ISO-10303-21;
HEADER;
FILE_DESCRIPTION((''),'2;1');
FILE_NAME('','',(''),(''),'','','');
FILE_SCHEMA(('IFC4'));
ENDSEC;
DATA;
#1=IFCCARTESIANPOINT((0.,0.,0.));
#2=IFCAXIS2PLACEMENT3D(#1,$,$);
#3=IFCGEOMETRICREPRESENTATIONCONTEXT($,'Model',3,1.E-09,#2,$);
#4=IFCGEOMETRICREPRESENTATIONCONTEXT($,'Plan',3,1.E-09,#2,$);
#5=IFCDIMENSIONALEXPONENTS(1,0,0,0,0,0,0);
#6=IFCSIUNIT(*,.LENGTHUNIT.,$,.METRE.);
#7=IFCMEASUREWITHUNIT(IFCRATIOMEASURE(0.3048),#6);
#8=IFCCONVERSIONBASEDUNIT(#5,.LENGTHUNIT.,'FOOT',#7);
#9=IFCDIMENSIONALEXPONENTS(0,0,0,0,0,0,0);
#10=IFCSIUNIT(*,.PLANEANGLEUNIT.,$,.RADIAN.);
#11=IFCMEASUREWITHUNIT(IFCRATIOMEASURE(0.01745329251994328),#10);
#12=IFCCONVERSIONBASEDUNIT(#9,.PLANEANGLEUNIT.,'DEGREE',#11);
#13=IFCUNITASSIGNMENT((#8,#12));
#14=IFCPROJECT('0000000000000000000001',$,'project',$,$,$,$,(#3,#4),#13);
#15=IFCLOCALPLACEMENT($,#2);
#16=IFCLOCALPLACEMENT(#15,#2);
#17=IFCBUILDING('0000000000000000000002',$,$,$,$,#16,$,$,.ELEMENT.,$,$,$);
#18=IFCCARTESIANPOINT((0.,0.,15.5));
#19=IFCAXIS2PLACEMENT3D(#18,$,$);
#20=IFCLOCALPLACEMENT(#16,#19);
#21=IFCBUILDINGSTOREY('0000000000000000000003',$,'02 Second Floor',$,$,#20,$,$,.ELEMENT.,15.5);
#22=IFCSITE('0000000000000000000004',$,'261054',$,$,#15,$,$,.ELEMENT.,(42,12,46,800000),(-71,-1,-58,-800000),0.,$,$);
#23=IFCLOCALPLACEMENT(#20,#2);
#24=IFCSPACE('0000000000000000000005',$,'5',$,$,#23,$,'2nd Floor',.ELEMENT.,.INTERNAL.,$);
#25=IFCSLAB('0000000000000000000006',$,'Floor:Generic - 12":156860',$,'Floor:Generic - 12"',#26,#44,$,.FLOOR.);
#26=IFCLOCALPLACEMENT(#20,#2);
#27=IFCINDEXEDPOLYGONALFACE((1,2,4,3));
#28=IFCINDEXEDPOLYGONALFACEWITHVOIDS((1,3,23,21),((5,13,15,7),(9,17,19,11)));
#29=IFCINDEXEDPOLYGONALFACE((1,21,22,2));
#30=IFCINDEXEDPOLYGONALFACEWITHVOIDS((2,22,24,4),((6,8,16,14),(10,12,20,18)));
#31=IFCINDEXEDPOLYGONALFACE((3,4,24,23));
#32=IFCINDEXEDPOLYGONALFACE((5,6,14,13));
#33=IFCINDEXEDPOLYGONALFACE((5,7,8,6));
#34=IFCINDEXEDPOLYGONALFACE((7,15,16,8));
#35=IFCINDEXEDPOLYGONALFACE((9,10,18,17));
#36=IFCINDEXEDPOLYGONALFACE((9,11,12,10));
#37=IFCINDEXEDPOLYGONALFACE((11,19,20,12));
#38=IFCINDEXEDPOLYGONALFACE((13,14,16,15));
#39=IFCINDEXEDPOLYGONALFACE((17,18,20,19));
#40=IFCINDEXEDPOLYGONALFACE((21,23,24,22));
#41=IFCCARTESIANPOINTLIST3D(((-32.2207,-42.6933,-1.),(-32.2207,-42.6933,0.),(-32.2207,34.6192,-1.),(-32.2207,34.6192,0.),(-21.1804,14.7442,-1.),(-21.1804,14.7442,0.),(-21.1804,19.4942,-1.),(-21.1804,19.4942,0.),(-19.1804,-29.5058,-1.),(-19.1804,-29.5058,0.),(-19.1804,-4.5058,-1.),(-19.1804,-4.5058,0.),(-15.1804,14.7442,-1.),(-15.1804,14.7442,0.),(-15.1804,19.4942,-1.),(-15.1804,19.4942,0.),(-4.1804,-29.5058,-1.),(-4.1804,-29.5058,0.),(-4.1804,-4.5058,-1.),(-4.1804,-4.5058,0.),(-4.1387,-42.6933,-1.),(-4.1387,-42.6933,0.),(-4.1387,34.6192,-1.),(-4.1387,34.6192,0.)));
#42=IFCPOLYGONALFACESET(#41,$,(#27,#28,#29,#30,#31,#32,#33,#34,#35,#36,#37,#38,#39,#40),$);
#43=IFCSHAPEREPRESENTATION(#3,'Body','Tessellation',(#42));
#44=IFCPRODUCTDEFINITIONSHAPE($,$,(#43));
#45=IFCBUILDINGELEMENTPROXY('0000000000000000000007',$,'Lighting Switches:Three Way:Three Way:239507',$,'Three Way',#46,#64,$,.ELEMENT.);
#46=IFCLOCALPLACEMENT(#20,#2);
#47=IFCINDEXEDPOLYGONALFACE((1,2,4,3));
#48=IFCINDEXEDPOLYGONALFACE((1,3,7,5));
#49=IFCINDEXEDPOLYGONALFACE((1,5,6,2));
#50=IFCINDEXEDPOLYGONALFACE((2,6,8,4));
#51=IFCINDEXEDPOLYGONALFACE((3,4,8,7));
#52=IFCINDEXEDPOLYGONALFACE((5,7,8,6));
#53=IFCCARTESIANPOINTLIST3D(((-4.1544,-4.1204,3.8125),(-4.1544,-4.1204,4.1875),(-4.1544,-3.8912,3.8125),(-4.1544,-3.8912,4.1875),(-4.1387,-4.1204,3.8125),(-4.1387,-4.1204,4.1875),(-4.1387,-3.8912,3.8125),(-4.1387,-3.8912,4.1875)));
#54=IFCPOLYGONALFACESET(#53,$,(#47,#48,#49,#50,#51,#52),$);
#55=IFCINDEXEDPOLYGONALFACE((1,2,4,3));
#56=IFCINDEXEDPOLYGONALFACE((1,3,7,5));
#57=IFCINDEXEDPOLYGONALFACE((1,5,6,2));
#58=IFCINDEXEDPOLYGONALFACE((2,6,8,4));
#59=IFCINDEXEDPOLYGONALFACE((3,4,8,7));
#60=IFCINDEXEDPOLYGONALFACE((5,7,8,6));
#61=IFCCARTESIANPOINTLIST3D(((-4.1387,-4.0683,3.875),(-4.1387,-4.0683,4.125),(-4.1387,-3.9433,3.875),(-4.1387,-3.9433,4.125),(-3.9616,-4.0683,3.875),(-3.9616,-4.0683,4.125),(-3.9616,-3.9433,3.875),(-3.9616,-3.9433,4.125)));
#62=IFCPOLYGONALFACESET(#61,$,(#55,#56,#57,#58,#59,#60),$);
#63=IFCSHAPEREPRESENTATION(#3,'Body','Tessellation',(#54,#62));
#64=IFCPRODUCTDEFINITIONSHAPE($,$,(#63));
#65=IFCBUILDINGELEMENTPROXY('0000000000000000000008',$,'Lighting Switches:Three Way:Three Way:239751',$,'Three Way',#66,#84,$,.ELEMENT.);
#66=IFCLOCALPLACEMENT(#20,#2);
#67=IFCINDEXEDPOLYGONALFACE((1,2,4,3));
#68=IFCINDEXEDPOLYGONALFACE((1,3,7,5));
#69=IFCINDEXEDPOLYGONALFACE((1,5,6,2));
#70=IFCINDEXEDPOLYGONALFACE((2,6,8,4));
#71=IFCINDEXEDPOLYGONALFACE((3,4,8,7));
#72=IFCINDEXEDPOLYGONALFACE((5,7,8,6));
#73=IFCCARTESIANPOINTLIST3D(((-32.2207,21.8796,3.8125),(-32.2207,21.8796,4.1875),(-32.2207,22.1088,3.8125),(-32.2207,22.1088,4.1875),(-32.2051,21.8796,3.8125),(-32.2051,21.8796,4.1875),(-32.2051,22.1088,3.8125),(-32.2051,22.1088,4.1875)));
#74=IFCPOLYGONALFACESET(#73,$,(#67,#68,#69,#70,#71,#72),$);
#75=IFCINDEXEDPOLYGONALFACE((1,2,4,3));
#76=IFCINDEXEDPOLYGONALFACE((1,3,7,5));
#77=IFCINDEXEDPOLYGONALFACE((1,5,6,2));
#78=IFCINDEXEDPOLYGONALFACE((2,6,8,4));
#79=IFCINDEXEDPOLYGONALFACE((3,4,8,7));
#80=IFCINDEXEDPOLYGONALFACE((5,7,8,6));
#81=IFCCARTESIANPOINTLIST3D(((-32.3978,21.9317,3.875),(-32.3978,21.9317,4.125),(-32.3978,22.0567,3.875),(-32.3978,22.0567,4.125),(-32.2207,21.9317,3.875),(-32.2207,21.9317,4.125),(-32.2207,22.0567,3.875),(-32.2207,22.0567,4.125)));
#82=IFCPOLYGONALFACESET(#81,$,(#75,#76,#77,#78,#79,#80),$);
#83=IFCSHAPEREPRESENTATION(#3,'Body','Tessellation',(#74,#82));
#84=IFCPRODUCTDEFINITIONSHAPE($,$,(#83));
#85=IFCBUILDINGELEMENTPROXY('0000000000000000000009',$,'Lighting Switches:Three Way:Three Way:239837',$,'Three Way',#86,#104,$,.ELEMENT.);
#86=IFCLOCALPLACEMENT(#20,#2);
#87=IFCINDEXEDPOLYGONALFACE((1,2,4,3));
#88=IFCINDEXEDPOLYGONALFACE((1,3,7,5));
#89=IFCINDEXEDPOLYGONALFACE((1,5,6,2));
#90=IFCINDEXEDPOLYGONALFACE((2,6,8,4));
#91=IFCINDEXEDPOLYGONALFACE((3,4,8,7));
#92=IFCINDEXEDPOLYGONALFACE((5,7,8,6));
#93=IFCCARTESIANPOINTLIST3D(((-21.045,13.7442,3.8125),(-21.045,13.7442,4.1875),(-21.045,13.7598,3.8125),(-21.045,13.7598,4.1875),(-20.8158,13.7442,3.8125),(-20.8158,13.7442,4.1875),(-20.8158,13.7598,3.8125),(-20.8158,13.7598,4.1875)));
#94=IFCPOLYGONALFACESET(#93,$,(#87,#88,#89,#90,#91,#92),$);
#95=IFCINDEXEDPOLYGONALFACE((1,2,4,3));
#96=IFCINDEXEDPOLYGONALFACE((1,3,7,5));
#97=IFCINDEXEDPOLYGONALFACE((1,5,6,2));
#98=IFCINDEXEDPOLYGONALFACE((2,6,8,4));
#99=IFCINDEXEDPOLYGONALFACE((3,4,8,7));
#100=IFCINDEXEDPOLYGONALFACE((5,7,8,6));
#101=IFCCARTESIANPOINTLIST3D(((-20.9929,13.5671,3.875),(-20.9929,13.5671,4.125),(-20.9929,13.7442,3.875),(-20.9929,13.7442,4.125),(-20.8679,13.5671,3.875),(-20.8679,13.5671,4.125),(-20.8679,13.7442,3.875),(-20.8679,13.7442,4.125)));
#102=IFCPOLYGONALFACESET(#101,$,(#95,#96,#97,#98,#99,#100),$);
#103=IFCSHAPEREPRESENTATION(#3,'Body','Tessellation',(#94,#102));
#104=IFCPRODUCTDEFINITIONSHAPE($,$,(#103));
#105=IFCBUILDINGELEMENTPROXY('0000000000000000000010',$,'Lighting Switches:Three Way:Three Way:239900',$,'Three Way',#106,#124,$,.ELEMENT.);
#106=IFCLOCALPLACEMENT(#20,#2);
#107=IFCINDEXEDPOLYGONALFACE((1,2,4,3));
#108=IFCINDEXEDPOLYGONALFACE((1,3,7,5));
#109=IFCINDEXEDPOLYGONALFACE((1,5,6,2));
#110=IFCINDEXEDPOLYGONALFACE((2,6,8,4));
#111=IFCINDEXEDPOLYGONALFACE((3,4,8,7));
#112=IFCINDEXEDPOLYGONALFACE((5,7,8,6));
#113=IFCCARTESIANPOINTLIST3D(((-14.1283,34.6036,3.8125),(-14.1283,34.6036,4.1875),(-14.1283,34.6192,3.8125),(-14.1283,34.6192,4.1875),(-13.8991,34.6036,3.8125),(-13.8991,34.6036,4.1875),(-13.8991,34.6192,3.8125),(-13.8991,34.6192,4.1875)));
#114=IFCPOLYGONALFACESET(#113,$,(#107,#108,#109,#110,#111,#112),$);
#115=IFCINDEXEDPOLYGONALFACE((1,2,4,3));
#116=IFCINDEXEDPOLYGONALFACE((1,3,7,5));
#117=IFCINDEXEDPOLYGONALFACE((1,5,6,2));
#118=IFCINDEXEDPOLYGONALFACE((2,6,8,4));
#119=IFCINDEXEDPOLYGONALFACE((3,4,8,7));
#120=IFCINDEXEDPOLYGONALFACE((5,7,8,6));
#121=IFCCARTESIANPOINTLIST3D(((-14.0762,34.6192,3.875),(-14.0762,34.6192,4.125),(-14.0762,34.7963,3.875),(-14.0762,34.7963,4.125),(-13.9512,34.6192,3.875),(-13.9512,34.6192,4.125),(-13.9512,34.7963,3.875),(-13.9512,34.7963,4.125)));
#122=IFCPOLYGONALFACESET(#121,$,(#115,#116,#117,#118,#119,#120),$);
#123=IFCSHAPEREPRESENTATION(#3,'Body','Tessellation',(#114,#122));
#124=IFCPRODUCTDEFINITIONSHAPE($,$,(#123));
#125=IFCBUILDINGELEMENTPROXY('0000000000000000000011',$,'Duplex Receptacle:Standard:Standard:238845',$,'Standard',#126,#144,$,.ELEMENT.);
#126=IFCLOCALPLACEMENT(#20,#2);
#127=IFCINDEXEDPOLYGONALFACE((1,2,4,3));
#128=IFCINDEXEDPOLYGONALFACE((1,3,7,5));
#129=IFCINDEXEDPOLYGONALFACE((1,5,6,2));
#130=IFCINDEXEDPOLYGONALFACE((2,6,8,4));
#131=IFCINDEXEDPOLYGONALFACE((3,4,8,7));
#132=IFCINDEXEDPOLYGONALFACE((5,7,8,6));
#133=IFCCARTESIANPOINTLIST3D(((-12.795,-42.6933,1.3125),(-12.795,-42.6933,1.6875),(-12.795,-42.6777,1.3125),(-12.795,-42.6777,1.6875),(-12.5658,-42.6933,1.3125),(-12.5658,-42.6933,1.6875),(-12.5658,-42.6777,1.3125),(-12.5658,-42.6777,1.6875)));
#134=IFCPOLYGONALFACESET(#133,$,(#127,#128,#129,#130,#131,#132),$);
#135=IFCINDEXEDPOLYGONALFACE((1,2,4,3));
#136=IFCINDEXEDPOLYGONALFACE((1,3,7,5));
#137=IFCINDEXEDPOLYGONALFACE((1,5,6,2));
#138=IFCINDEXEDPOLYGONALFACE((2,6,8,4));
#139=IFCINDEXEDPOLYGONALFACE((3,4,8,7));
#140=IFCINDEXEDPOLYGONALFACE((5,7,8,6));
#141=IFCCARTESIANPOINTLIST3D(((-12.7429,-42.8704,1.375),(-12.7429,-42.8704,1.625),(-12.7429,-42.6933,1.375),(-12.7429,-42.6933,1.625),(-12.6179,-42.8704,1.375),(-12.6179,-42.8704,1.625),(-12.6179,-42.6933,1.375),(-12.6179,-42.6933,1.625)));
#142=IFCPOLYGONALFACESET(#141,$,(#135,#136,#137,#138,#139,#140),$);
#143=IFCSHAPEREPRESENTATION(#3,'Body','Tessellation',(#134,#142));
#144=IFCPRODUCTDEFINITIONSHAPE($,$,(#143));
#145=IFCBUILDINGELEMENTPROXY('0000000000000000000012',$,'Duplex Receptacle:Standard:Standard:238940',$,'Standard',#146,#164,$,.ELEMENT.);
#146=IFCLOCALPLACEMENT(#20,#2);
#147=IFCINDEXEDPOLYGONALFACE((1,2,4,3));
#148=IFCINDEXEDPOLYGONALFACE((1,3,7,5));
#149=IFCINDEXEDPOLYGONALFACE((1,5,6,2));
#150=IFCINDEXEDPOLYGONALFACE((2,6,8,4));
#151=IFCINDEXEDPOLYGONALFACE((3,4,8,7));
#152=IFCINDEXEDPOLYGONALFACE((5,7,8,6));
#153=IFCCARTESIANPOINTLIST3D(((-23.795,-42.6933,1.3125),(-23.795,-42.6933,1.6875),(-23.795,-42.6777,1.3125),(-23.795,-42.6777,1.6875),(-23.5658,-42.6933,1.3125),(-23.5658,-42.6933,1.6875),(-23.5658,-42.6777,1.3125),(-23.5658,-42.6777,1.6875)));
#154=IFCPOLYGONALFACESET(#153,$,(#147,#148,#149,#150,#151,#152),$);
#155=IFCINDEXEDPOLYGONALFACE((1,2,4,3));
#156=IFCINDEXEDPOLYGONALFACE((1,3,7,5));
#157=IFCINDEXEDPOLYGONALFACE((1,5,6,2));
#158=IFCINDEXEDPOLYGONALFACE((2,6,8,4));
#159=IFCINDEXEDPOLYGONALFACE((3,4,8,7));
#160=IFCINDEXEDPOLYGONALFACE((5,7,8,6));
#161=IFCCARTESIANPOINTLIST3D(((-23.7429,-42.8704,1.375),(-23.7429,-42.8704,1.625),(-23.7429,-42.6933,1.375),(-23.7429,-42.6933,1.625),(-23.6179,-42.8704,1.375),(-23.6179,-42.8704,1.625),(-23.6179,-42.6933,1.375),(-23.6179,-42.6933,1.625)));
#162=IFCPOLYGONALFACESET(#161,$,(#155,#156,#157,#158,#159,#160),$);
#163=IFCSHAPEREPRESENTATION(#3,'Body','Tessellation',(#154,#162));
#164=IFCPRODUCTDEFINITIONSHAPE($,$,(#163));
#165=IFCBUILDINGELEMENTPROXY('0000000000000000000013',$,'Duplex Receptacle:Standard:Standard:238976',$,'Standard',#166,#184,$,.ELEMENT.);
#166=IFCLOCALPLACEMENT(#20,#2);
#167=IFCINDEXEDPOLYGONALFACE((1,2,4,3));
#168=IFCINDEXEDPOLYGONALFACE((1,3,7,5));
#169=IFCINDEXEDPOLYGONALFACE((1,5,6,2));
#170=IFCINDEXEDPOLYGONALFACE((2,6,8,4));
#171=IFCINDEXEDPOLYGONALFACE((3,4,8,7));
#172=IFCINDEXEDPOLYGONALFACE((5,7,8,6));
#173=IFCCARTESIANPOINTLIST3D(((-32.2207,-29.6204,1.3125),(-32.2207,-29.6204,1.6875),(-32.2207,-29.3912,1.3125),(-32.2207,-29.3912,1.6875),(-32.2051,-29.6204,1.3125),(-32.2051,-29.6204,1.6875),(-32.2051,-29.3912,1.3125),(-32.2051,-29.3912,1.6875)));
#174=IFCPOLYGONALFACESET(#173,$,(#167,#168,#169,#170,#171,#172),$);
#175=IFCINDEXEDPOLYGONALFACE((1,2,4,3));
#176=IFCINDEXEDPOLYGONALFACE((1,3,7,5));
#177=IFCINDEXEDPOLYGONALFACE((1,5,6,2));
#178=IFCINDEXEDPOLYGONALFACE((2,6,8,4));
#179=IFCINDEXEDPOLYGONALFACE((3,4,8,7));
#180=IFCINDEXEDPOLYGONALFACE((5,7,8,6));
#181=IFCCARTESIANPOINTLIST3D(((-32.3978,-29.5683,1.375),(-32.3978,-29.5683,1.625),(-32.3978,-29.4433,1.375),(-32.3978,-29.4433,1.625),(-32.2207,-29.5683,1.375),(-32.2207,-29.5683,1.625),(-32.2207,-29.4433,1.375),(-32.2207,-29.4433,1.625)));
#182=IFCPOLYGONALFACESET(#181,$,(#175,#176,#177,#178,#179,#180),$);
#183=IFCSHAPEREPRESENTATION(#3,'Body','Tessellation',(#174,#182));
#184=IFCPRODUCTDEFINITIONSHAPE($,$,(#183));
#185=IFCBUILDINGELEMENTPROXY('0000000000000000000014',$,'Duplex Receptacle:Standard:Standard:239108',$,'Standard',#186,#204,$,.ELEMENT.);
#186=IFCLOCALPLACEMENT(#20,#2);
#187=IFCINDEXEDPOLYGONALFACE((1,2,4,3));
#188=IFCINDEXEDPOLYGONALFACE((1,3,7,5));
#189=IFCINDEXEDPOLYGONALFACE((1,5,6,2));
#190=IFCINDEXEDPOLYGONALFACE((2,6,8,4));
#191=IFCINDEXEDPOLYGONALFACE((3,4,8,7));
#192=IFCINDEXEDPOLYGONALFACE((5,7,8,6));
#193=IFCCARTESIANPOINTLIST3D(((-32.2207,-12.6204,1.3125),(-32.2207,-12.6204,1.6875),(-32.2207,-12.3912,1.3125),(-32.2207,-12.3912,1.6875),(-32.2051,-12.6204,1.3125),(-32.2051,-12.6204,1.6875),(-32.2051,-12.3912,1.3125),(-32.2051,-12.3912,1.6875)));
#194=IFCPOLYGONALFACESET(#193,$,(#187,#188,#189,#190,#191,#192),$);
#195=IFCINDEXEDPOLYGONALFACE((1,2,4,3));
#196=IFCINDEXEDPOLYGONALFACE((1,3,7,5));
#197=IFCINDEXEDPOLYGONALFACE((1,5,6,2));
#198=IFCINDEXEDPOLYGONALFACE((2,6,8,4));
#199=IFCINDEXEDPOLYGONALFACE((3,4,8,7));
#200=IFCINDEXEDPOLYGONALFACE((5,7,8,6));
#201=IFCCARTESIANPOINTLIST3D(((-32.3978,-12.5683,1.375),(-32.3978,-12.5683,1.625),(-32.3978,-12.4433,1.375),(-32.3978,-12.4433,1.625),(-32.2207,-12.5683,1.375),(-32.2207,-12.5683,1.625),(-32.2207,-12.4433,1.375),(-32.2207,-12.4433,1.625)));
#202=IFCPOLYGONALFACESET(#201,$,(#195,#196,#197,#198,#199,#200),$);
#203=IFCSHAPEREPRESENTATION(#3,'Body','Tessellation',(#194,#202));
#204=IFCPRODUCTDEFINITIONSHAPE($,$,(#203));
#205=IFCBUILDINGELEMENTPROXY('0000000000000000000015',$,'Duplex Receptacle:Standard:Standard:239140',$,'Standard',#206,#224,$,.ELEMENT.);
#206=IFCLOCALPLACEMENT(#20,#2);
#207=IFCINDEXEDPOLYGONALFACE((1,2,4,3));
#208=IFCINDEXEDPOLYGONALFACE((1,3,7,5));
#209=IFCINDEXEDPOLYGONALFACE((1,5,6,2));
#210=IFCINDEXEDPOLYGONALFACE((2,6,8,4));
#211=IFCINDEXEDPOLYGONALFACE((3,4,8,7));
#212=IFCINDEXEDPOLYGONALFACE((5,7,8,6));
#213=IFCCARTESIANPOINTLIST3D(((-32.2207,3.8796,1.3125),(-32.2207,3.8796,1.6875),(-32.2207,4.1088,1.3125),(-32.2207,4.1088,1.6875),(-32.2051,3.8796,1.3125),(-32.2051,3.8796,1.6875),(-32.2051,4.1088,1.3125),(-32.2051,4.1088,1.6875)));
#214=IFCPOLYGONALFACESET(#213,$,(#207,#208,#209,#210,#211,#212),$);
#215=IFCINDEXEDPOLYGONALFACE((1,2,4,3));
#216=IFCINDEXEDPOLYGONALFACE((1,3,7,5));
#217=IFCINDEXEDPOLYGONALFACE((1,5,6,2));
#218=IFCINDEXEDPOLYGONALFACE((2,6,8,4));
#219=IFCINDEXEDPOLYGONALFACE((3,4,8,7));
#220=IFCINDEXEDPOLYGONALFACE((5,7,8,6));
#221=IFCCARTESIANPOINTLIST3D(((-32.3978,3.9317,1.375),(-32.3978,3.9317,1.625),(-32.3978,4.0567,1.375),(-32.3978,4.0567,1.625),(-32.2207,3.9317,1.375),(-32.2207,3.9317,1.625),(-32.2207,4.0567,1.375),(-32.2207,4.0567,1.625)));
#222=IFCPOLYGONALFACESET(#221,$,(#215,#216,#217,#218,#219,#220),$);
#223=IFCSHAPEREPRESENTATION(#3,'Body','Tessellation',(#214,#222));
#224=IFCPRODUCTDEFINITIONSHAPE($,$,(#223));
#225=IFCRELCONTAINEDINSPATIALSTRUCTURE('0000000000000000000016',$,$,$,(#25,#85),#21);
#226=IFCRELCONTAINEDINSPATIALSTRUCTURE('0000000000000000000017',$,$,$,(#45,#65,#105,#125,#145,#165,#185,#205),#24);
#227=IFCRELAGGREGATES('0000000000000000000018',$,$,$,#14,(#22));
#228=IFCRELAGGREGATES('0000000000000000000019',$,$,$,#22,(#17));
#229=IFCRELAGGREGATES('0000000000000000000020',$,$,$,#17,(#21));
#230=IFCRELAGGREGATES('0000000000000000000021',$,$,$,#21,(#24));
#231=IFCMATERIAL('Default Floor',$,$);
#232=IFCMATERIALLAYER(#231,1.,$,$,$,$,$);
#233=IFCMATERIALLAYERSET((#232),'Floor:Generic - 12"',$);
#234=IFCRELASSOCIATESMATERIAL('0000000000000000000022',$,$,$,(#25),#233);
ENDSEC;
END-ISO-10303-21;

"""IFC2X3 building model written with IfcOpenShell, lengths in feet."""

from ifc_helpers import new_model, entity, si_unit, converted_unit, frame, frame_2d, origin, origin_2d_with_axis, place, context, project, spatial, rectangle, extrude, source, transform, mapped, material, layer, layer_set, layer_usage, element, save


model = new_model("IFC2X3")

# Units and contexts
model_context = context("Model", 3, precision=1e-09, world=origin())
plan_context = context("Plan", 3, precision=1e-09, world=origin())
ifc_project = project(units=[converted_unit("LENGTHUNIT", "FOOT", entity("IfcRatioMeasure", 0.3048), si_unit("LENGTHUNIT", "METRE"), dimensions=[1, 0, 0, 0, 0, 0, 0]), converted_unit("PLANEANGLEUNIT", "DEGREE", entity("IfcRatioMeasure", 0.01745329251994328), si_unit("PLANEANGLEUNIT", "RADIAN"), dimensions=[0, 0, 0, 0, 0, 0, 0])], contexts=[model_context, plan_context])

# Site, building, storey
site_placement = place(None, origin())
site = spatial("IfcSite", under=ifc_project, at=site_placement, Name="261054", CompositionType="ELEMENT", RefLatitude=(42, 12, 46, 800000), RefLongitude=(-71, -1, -58, -800000), RefElevation=0.0)
building_placement = place(site_placement, origin())
building = spatial("IfcBuilding", under=site, at=building_placement, CompositionType="ELEMENT")
storey_placement = place(building_placement, frame((0.0, 0.0, 15.5)))
storey = spatial("IfcBuildingStorey", under=building, at=storey_placement, Name="02 Second Floor", CompositionType="ELEMENT", Elevation=15.5)

# Slab, openings
ifc_material = material(Name="Default Floor")
ifc_layer = layer(ifc_material, 1.0)
ifc_layer_set = layer_set([ifc_layer], Name="Floor:Generic - 12\"")
ifc_layer_usage_1 = layer_usage(ifc_layer_set, "AXIS3", "POSITIVE", 0.0)
slab_1_placement = place(storey_placement, frame((-32.2207, -42.6933, -1.0)))
slab_1 = element("IfcSlab", 1, at=slab_1_placement, inside=storey, material=ifc_layer_usage_1, Name="Floor:Generic - 12\":156860", ObjectType="Floor:Generic - 12\"", PredefinedType="FLOOR", context=model_context, shape_type="SweptSolid", body=[
    extrude(rectangle(XDim=77.3125, YDim=28.082, at=frame_2d((0.0, 0.0), x_axis=(0.0, -1.0))), frame((14.041, 38.6563, 1.0), z_axis=(0.0, 0.0, -1.0), x_axis=(-1.0, 0.0, 0.0)), (0.0, 0.0, 1.0), 1.0),
])
opening_1_placement = place(storey_placement, frame((-32.2207, -42.6933, -1.0)))
element("IfcOpeningElement", 2, at=opening_1_placement, cuts=slab_1, ObjectType="Opening", context=model_context, shape_type="SweptSolid", body=[
    extrude(rectangle(XDim=25.0, YDim=15.0, at=frame_2d((-6.4993, -12.9688), x_axis=(0.0, -1.0))), frame((14.041, 38.6563, 1.0), z_axis=(0.0, 0.0, -1.0), x_axis=(-1.0, 0.0, 0.0)), (0.0, 0.0, 1.0), 1.0),
])
opening_2_placement = place(storey_placement, frame((-32.2207, -42.6933, -1.0)))
element("IfcOpeningElement", 3, at=opening_2_placement, cuts=slab_1, ObjectType="Opening", context=model_context, shape_type="SweptSolid", body=[
    extrude(rectangle(XDim=6.0, YDim=4.75, at=frame_2d((0.0007, 21.1562), x_axis=(-1.0, 0.0))), frame((14.041, 38.6563, 1.0), z_axis=(0.0, 0.0, -1.0), x_axis=(-1.0, 0.0, 0.0)), (0.0, 0.0, 1.0), 1.0),
])

# Shared definitions
space_placement = place(storey_placement, origin())
space = spatial("IfcSpace", under=storey, at=space_placement, Name="5", LongName="2nd Floor", CompositionType="ELEMENT", InteriorOrExteriorSpace="INTERNAL")

# Building element proxies
shared_shape_1 = source(origin(), model_context, "Body", "SweptSolid", [
    extrude(rectangle(XDim=0.2292, YDim=0.375, at=origin_2d_with_axis()), frame((0.0, 0.0, 0.0), z_axis=(0.0, 0.0, 1.0), x_axis=(-1.0, 0.0, 0.0)), (0.0, 0.0, 1.0), 0.0156),
    extrude(rectangle(XDim=0.125, YDim=0.25, at=origin_2d_with_axis()), frame((0.0, 0.0, -0.1771), z_axis=(0.0, 0.0, 1.0), x_axis=(-1.0, 0.0, 0.0)), (0.0, 0.0, 1.0), 0.1771),
])
for number, where, z_axis, x_axis, name in (
    (4, (-4.1387, -4.0058, 4.0), (-1.0, 0.0, 0.0), (0.0, -1.0, 0.0), "Lighting Switches:Three Way:Three Way:239507"),
    (5, (-32.2207, 21.9942, 4.0), (1.0, 0.0, 0.0), (0.0, 1.0, 0.0), "Lighting Switches:Three Way:Three Way:239751"),
):
    element("IfcBuildingElementProxy", number, at=place(space_placement, frame(where, z_axis=z_axis, x_axis=x_axis)), inside=space, Name=name, ObjectType="Three Way", CompositionType="ELEMENT", context=model_context, shape_type="MappedRepresentation", body=[
        mapped(shared_shape_1, transform((0.0, 0.0, 0.0), scale=1.0)),
    ])
proxy_1_placement = place(storey_placement, frame((-20.9304, 13.7442, 4.0), z_axis=(0.0, 1.0, 0.0), x_axis=(1.0, 0.0, 0.0)))
element("IfcBuildingElementProxy", 6, at=proxy_1_placement, inside=storey, Name="Lighting Switches:Three Way:Three Way:239837", ObjectType="Three Way", CompositionType="ELEMENT", context=model_context, shape_type="MappedRepresentation", body=[
    mapped(shared_shape_1, transform((0.0, 0.0, 0.0), scale=1.0)),
])
proxy_2_placement = place(space_placement, frame((-14.0137, 34.6192, 4.0), z_axis=(0.0, -1.0, 0.0), x_axis=(1.0, 0.0, 0.0)))
element("IfcBuildingElementProxy", 7, at=proxy_2_placement, inside=space, Name="Lighting Switches:Three Way:Three Way:239900", ObjectType="Three Way", CompositionType="ELEMENT", context=model_context, shape_type="MappedRepresentation", body=[
    mapped(shared_shape_1, transform((0.0, 0.0, 0.0), scale=1.0)),
])
shared_shape_2 = source(origin(), model_context, "Body", "SweptSolid", [
    extrude(rectangle(XDim=0.2292, YDim=0.375, at=origin_2d_with_axis()), frame((0.0, 0.0, 0.0), z_axis=(0.0, 0.0, 1.0), x_axis=(-1.0, 0.0, 0.0)), (0.0, 0.0, 1.0), 0.0156),
    extrude(rectangle(XDim=0.125, YDim=0.25, at=origin_2d_with_axis()), frame((0.0, 0.0, -0.1771), z_axis=(0.0, 0.0, 1.0), x_axis=(-1.0, 0.0, 0.0)), (0.0, 0.0, 1.0), 0.1771),
])
for number, where, z_axis, x_axis, name in (
    (8, (-12.6804, -42.6933, 1.5), (0.0, 1.0, 0.0), (-1.0, 0.0, 0.0), "Duplex Receptacle:Standard:Standard:238845"),
    (9, (-23.6804, -42.6933, 1.5), (0.0, 1.0, 0.0), (-1.0, 0.0, 0.0), "Duplex Receptacle:Standard:Standard:238940"),
    (10, (-32.2207, -29.5058, 1.5), (1.0, 0.0, 0.0), (0.0, 1.0, 0.0), "Duplex Receptacle:Standard:Standard:238976"),
    (11, (-32.2207, -12.5058, 1.5), (1.0, 0.0, 0.0), (0.0, 1.0, 0.0), "Duplex Receptacle:Standard:Standard:239108"),
    (12, (-32.2207, 3.9942, 1.5), (1.0, 0.0, 0.0), (0.0, 1.0, 0.0), "Duplex Receptacle:Standard:Standard:239140"),
):
    element("IfcBuildingElementProxy", number, at=place(space_placement, frame(where, z_axis=z_axis, x_axis=x_axis)), inside=space, Name=name, ObjectType="Standard", CompositionType="ELEMENT", context=model_context, shape_type="MappedRepresentation", body=[
        mapped(shared_shape_2, transform((0.0, 0.0, 0.0), scale=1.0)),
    ])

save(model, "model.ifc")
